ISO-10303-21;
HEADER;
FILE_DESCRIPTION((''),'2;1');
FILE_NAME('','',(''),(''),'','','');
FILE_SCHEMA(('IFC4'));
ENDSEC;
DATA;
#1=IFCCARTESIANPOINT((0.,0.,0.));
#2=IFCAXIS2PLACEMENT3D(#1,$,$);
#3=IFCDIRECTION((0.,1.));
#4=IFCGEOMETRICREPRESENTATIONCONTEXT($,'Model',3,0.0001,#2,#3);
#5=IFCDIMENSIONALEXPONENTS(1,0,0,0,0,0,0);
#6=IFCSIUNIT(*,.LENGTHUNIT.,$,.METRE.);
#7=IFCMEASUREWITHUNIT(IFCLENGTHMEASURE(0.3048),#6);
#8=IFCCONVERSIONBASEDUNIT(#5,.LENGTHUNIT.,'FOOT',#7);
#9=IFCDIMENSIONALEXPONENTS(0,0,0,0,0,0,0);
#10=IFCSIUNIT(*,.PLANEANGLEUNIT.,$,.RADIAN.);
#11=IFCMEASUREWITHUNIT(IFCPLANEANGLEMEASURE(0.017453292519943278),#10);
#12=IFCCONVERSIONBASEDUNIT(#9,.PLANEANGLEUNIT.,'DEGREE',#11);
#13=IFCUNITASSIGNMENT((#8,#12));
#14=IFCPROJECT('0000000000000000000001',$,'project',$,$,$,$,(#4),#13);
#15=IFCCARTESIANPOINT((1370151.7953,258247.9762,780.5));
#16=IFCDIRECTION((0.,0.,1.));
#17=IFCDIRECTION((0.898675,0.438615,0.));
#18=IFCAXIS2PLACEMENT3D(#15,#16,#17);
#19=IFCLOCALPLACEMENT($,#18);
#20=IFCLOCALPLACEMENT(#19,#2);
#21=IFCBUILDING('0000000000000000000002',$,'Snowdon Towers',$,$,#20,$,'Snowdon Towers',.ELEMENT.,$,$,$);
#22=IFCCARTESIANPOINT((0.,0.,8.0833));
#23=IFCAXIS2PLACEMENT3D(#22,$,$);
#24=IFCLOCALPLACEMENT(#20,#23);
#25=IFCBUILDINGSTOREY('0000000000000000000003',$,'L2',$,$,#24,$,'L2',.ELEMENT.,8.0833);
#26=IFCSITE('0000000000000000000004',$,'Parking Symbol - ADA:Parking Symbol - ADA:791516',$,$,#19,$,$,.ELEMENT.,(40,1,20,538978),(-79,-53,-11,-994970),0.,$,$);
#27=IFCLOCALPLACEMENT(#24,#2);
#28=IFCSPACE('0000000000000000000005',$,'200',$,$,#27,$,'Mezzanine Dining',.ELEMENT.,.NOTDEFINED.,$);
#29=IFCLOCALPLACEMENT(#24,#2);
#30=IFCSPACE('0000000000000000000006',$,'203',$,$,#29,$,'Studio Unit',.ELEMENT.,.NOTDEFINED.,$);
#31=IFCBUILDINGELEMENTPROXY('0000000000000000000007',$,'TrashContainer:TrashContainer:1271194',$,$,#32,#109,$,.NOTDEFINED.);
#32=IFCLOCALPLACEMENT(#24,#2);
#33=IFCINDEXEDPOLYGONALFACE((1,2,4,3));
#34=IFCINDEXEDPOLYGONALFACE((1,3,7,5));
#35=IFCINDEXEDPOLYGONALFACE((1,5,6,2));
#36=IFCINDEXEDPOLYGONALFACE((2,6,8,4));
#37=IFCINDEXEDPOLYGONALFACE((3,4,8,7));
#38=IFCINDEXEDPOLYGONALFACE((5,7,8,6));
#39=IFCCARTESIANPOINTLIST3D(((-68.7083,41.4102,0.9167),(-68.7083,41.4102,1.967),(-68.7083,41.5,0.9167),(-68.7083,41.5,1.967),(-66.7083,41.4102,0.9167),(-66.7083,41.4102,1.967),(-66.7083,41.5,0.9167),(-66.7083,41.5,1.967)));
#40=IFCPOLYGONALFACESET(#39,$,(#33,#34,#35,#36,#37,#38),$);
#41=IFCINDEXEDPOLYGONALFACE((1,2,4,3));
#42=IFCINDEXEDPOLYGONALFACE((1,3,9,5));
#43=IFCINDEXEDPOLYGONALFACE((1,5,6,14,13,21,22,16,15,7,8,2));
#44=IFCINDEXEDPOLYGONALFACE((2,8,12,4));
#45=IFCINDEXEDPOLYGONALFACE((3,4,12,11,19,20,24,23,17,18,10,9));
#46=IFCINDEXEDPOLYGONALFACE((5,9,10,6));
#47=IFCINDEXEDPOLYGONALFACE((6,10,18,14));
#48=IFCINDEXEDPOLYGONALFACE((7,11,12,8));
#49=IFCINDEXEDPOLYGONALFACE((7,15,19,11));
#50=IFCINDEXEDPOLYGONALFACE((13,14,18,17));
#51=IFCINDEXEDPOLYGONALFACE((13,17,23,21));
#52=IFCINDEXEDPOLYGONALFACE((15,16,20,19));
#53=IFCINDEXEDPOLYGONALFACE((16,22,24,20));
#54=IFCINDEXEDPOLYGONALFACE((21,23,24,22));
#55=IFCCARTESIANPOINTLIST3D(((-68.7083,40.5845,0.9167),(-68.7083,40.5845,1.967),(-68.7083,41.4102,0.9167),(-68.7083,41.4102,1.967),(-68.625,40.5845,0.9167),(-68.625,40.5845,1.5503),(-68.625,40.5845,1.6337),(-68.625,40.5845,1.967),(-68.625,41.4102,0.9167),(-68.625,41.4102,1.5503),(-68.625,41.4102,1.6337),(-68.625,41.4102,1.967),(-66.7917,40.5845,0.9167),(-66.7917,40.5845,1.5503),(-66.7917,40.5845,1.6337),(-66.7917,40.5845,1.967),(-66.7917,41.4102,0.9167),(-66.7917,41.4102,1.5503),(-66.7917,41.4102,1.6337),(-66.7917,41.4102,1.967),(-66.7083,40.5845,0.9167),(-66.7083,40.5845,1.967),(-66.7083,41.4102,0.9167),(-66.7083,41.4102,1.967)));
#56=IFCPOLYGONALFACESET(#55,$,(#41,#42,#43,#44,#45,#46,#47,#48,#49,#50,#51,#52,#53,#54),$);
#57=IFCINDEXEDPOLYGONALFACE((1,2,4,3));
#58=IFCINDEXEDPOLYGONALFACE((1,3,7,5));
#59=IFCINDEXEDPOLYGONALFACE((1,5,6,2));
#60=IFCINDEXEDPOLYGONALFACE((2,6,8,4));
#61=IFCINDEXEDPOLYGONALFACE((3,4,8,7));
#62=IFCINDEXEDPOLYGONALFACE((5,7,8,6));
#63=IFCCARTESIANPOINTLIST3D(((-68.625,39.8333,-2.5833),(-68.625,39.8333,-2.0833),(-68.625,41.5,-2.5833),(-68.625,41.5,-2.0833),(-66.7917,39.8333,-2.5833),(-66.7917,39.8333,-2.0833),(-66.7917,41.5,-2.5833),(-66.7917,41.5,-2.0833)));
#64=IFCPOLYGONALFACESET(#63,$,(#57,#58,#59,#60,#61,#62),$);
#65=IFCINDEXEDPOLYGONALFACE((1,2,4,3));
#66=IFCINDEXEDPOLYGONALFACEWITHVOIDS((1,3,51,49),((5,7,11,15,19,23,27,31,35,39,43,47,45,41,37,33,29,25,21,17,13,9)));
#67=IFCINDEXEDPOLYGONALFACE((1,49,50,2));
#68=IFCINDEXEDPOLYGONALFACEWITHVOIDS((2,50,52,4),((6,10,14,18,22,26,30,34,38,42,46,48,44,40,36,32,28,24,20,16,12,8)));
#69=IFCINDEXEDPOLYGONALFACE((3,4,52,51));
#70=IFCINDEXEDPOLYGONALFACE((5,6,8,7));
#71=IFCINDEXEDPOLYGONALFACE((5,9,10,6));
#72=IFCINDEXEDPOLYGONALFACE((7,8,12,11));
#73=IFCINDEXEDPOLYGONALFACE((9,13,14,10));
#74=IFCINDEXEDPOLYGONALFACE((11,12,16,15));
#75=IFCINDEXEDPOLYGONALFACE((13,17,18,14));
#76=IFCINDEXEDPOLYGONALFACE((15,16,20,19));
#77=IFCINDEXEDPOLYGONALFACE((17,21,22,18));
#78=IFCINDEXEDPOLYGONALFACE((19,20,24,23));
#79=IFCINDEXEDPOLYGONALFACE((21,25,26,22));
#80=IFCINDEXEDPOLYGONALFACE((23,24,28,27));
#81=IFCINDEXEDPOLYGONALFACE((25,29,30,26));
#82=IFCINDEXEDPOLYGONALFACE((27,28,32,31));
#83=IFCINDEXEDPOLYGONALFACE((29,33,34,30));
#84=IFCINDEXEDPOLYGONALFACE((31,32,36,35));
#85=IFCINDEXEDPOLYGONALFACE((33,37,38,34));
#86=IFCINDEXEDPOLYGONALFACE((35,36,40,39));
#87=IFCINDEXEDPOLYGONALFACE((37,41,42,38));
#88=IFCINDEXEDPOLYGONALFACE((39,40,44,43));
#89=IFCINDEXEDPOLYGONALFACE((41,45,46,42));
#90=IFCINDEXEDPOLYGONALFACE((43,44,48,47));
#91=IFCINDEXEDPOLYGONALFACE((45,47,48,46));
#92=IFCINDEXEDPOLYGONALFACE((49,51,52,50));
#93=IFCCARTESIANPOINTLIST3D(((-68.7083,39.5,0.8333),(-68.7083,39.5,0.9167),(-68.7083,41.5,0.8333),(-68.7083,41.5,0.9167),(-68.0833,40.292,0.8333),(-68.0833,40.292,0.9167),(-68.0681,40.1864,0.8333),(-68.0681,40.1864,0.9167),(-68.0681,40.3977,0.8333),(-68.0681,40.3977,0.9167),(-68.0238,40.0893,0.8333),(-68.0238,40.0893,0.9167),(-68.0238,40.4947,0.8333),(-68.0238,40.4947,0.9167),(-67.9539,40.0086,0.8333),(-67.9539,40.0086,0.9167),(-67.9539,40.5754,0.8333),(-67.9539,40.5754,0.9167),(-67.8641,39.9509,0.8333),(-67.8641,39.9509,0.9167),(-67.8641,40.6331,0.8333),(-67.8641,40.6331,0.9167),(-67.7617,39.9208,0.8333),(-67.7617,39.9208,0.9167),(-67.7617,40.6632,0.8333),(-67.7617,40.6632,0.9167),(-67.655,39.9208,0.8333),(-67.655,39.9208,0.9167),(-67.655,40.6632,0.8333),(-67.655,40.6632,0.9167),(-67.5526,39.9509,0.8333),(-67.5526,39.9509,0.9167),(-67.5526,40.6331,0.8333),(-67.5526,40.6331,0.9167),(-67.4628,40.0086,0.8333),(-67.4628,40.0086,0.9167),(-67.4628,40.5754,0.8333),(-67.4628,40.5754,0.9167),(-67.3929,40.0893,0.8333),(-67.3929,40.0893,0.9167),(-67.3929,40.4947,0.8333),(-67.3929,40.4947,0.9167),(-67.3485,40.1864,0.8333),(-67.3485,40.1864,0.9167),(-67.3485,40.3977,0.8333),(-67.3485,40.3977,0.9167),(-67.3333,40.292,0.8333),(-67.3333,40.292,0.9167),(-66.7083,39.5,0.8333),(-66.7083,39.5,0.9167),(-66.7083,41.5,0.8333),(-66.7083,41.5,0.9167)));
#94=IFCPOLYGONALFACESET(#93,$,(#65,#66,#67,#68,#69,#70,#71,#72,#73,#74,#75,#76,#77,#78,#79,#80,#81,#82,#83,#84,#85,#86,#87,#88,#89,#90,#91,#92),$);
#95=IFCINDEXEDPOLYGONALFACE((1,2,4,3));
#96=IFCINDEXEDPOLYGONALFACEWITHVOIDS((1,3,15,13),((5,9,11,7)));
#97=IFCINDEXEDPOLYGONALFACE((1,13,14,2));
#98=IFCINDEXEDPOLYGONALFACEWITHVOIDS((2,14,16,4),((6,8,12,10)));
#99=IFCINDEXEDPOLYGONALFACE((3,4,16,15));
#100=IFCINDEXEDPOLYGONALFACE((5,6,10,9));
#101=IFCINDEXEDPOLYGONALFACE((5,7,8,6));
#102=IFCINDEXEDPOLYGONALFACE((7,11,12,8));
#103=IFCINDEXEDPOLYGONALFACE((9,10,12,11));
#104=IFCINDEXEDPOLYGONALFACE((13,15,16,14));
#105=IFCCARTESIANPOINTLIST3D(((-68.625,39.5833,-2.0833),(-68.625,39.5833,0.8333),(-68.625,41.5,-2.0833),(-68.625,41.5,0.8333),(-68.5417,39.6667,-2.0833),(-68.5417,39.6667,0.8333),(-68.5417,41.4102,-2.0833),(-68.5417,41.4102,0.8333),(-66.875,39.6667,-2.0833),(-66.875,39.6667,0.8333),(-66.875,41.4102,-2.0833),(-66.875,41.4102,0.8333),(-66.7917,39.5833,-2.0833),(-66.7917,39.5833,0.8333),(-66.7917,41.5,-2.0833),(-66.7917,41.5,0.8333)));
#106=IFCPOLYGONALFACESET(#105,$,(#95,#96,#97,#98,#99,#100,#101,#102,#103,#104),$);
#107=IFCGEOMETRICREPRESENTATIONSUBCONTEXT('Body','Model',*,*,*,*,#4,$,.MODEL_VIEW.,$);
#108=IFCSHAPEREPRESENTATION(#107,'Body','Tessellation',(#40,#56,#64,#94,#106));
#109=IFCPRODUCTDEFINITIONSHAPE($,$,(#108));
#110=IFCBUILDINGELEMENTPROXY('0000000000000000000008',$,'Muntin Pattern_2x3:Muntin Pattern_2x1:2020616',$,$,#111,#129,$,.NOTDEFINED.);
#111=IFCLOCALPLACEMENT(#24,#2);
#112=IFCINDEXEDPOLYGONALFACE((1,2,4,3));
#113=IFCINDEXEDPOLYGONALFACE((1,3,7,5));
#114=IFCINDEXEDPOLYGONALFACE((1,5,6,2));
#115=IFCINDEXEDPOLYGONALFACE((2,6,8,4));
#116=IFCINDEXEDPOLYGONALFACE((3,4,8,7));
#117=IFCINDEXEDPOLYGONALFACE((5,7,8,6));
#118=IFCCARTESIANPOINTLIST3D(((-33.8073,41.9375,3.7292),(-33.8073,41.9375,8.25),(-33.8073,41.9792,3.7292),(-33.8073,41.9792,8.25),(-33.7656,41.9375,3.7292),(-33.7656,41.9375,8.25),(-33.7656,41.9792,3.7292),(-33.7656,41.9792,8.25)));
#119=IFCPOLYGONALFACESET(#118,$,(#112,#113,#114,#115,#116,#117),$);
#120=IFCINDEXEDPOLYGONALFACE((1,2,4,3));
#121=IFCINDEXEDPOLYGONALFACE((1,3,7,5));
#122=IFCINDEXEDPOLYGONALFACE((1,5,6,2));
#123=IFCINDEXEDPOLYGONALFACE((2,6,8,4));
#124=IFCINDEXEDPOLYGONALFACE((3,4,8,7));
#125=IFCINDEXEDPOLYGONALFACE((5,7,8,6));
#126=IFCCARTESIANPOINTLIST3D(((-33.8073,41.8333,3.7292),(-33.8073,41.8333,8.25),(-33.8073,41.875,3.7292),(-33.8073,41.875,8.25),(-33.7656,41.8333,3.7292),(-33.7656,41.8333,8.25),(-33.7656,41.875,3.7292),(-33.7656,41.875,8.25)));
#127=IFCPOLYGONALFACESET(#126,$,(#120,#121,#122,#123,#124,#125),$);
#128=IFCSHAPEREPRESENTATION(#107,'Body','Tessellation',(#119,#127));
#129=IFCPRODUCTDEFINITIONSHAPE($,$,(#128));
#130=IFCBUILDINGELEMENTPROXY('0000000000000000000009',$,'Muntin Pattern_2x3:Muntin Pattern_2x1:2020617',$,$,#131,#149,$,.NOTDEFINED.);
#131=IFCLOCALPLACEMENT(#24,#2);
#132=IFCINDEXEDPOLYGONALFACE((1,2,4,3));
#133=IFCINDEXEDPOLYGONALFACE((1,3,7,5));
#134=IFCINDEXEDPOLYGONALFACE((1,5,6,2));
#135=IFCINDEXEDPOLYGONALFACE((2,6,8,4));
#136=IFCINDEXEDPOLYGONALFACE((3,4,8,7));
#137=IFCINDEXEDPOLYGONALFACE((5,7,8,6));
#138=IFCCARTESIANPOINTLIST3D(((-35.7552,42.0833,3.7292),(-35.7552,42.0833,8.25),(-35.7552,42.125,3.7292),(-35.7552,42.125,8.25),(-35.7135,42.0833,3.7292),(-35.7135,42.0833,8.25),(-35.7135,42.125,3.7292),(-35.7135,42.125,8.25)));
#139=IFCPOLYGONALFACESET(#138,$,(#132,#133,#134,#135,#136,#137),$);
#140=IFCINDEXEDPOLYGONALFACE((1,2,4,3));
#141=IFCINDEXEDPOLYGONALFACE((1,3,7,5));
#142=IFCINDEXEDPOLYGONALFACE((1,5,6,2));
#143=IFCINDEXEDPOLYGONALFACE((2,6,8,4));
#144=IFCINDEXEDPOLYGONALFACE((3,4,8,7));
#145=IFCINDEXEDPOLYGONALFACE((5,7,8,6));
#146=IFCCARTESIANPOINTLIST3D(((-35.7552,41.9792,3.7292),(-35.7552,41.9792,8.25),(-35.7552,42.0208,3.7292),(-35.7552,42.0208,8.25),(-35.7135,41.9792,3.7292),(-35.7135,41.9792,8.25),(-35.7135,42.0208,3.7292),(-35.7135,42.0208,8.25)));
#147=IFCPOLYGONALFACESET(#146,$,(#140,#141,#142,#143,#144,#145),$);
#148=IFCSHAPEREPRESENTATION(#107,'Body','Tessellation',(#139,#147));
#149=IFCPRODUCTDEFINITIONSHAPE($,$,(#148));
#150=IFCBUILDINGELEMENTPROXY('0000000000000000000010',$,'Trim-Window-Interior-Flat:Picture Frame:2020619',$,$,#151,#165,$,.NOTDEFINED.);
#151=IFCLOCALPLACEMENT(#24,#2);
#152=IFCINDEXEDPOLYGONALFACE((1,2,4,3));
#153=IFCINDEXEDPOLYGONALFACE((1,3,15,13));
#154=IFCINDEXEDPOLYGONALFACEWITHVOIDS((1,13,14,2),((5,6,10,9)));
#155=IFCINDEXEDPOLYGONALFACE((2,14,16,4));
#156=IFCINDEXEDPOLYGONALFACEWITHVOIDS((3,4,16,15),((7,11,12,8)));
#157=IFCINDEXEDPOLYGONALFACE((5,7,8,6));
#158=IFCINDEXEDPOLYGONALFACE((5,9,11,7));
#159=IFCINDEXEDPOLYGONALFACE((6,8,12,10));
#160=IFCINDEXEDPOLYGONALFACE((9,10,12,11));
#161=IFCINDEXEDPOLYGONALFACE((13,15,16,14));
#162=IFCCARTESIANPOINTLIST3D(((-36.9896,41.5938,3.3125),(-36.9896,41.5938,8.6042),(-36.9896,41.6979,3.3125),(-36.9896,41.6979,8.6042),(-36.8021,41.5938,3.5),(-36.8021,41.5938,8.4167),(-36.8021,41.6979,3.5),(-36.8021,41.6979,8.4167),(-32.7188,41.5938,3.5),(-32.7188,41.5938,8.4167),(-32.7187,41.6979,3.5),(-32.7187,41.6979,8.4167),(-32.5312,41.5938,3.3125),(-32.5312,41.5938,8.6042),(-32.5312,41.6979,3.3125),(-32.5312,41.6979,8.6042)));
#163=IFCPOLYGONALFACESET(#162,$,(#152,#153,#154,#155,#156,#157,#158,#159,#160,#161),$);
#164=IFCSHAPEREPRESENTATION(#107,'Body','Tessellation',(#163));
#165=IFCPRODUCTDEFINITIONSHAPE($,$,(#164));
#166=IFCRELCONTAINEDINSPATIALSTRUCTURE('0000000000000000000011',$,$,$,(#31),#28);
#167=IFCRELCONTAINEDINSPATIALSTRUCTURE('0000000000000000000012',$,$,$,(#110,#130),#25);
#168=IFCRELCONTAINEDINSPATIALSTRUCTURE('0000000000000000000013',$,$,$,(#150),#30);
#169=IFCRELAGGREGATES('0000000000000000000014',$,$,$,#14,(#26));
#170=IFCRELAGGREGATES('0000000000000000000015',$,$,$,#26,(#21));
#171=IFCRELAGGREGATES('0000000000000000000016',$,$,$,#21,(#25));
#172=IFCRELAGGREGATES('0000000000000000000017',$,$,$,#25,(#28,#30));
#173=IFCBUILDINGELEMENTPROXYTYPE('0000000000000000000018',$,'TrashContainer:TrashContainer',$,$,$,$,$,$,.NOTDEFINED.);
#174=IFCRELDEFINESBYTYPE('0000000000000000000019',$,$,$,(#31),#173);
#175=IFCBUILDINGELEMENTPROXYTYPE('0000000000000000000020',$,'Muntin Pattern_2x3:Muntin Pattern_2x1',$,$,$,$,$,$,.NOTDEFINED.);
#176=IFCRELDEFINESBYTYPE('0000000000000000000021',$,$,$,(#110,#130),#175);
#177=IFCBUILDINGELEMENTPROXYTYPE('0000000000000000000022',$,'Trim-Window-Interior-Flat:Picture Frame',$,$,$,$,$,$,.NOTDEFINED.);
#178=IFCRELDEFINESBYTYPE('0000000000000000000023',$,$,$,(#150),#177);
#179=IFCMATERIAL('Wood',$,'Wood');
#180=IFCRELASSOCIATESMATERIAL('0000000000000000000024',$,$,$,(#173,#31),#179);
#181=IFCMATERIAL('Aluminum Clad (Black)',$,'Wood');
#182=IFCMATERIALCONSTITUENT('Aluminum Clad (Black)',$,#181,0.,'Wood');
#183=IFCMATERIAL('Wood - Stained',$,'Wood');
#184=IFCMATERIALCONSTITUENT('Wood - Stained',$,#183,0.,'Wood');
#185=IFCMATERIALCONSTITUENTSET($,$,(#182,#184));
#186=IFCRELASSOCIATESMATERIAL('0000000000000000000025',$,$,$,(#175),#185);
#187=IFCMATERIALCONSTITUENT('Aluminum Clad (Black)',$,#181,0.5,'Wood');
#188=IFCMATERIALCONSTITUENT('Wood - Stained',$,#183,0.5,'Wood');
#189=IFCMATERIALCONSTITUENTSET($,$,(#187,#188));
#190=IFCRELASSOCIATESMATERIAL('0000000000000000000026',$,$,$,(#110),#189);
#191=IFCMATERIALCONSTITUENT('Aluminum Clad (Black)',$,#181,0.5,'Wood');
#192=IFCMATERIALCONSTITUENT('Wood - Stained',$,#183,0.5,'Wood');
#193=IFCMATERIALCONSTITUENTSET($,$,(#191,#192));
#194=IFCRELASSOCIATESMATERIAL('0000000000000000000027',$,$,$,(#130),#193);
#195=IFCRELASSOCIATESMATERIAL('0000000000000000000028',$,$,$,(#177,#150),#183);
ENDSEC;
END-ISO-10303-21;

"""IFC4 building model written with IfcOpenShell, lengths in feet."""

from ifc_helpers import new_model, entity, si_unit, converted_unit, direction, frame, origin, place, context, subcontext, project, spatial, arc, indexed_curve, outline, extrude, source, transform, mapped, material, constituent, constituent_set, type_object, type_shapes, element, save


model = new_model("IFC4")

# Units and contexts
model_context = context("Model", 3, precision=0.0001, world=origin(), true_north=direction((0.0, 1.0)))
body_context = subcontext(model_context, "Body", "Model", "MODEL_VIEW")
ifc_project = project(units=[converted_unit("LENGTHUNIT", "FOOT", entity("IfcLengthMeasure", 0.3048), si_unit("LENGTHUNIT", "METRE"), dimensions=[1, 0, 0, 0, 0, 0, 0]), converted_unit("PLANEANGLEUNIT", "DEGREE", entity("IfcPlaneAngleMeasure", 0.017453292519943278), si_unit("PLANEANGLEUNIT", "RADIAN"), dimensions=[0, 0, 0, 0, 0, 0, 0])], contexts=[model_context])

# Site, building, storey
site_placement = place(None, frame((1370151.7953, 258247.9762, 780.5), z_axis=(0.0, 0.0, 1.0), x_axis=(0.898675, 0.438615, 0.0)))
site = spatial("IfcSite", under=ifc_project, at=site_placement, Name="Parking Symbol - ADA:Parking Symbol - ADA:791516", CompositionType="ELEMENT", RefLatitude=(40, 1, 20, 538978), RefLongitude=(-79, -53, -11, -994970), RefElevation=0.0)
building_placement = place(site_placement, origin())
building = spatial("IfcBuilding", under=site, at=building_placement, Name="Snowdon Towers", LongName="Snowdon Towers", CompositionType="ELEMENT")
storey_placement = place(building_placement, frame((0.0, 0.0, 8.0833)))
storey = spatial("IfcBuildingStorey", under=building, at=storey_placement, Name="L2", LongName="L2", CompositionType="ELEMENT", Elevation=8.0833)

# Shared definitions
space_1_placement = place(storey_placement, origin())
space_1 = spatial("IfcSpace", under=storey, at=space_1_placement, Name="200", LongName="Mezzanine Dining", CompositionType="ELEMENT", PredefinedType="NOTDEFINED")

# Building element proxies
ifc_material_1 = material(Name="Wood", Category="Wood")
building_element_proxy_type_1 = type_object("IfcBuildingElementProxyType", Name="TrashContainer:TrashContainer", PredefinedType="NOTDEFINED", material=ifc_material_1)
shared_shape_1 = source(origin(), body_context, "Body", "SweptSolid", [
    extrude(outline(indexed_curve([(-1.0, -0.0449), (1.0, -0.0449), (1.0, 0.0449), (-1.0, 0.0449), (-1.0, -0.0449)], self_intersect=False)), frame((1.0, 1.9551, 3.5), z_axis=(0.0, 0.0, 1.0), x_axis=(-1.0, 0.0, 0.0)), (0.0, 0.0, 1.0), 1.0503),
    extrude(outline(indexed_curve([(-1.0, -0.4751), (-0.9167, -0.4751), (-0.9167, -0.1418), (0.9167, -0.1418), (0.9167, -0.4751), (1.0, -0.4751), (1.0, 0.5752), (0.9167, 0.5752), (0.9167, -0.0584), (-0.9167, -0.0584), (-0.9167, 0.5752), (-1.0, 0.5752), (-1.0, -0.4751)], self_intersect=False)), frame((1.0, 1.0845, 4.0752), z_axis=(0.0, 1.0, 0.0), x_axis=(1.0, 0.0, 0.0)), (0.0, 0.0, 1.0), 0.8256),
    extrude(outline(indexed_curve([(-0.9167, -0.8333), (0.9167, -0.8333), (0.9167, 0.8333), (-0.9167, 0.8333), (-0.9167, -0.8333)], self_intersect=False)), frame((1.0, 1.1667, 0.0), z_axis=(0.0, 0.0, 1.0), x_axis=(-1.0, 0.0, 0.0)), (0.0, 0.0, 1.0), 0.5),
    extrude(outline(indexed_curve([(-1.0, -1.0), (1.0, -1.0), (1.0, 1.0), (-1.0, 1.0), (-1.0, -1.0)], self_intersect=False), holes=[indexed_curve([(0.208, -0.375), (-0.167, 0.0), (0.208, 0.375), (0.583, 0.0)], segments=[arc(1, 2, 3), arc(3, 4, 1)], self_intersect=False)]), frame((1.0, 1.0, 3.4167), z_axis=(0.0, 0.0, 1.0), x_axis=(0.0, -1.0, 0.0)), (0.0, 0.0, 1.0), 0.0833),
    extrude(outline(indexed_curve([(-0.9583, -0.9167), (0.9583, -0.9167), (0.9583, 0.9167), (-0.9583, 0.9167), (-0.9583, -0.9167)], self_intersect=False), holes=[indexed_curve([(-0.8685, -0.8333), (-0.8685, 0.8333), (0.875, 0.8333), (0.875, -0.8333), (-0.8685, -0.8333)], self_intersect=False)]), frame((1.0, 1.0417, 0.5), z_axis=(0.0, 0.0, 1.0), x_axis=(0.0, -1.0, 0.0)), (0.0, 0.0, 1.0), 2.9167),
])
type_shapes(building_element_proxy_type_1, [shared_shape_1])
proxy_1_placement = place(space_1_placement, frame((-68.7083, 39.5, -2.5833)))
element("IfcBuildingElementProxy", 1, at=proxy_1_placement, inside=space_1, type_object=building_element_proxy_type_1, material=ifc_material_1, Name="TrashContainer:TrashContainer:1271194", PredefinedType="NOTDEFINED", context=body_context, shape_type="MappedRepresentation", body=[
    mapped(shared_shape_1, transform((0.0, 0.0, 0.0), scale=1.0)),
])
ifc_material_2 = material(Name="Aluminum Clad (Black)", Category="Wood")
ifc_constituent_1 = constituent(ifc_material_2, Name="Aluminum Clad (Black)", Category="Wood", fraction=0.5)
ifc_material_3 = material(Name="Wood - Stained", Category="Wood")
ifc_constituent_2 = constituent(ifc_material_3, Name="Wood - Stained", Category="Wood", fraction=0.5)
ifc_constituent_set_1 = constituent_set(constituents=[ifc_constituent_1, ifc_constituent_2])
ifc_constituent_3 = constituent(ifc_material_2, Name="Aluminum Clad (Black)", Category="Wood", fraction=0.0)
ifc_constituent_4 = constituent(ifc_material_3, Name="Wood - Stained", Category="Wood", fraction=0.0)
ifc_constituent_set_2 = constituent_set(constituents=[ifc_constituent_3, ifc_constituent_4])
building_element_proxy_type_2 = type_object("IfcBuildingElementProxyType", Name="Muntin Pattern_2x3:Muntin Pattern_2x1", PredefinedType="NOTDEFINED", material=ifc_constituent_set_2)
shared_shape_2 = source(origin(), body_context, "Body", "SweptSolid", [
    extrude(outline(indexed_curve([(-0.0208, -0.0208), (0.0208, -0.0208), (0.0208, 0.0208), (-0.0208, 0.0208), (-0.0208, -0.0208)], self_intersect=False)), frame((0.0, 0.0521, 0.0), z_axis=(0.0, 0.0, 1.0), x_axis=(0.0, -1.0, 0.0)), (0.0, 0.0, 1.0), 4.5208),
    extrude(outline(indexed_curve([(-0.0208, -0.0208), (0.0208, -0.0208), (0.0208, 0.0208), (-0.0208, 0.0208), (-0.0208, -0.0208)], self_intersect=False)), frame((0.0, -0.0521, 0.0), z_axis=(0.0, 0.0, 1.0), x_axis=(0.0, -1.0, 0.0)), (0.0, 0.0, 1.0), 4.5208),
])
type_shapes(building_element_proxy_type_2, [shared_shape_2])
proxy_2_placement = place(storey_placement, frame((-33.7865, 41.9063, 3.7292)))
element("IfcBuildingElementProxy", 2, at=proxy_2_placement, inside=storey, type_object=building_element_proxy_type_2, material=ifc_constituent_set_1, Name="Muntin Pattern_2x3:Muntin Pattern_2x1:2020616", PredefinedType="NOTDEFINED", context=body_context, shape_type="MappedRepresentation", body=[
    mapped(shared_shape_2, transform((0.0, 0.0, 0.0), scale=1.0)),
])
ifc_constituent_5 = constituent(ifc_material_2, Name="Aluminum Clad (Black)", Category="Wood", fraction=0.5)
ifc_constituent_6 = constituent(ifc_material_3, Name="Wood - Stained", Category="Wood", fraction=0.5)
ifc_constituent_set_3 = constituent_set(constituents=[ifc_constituent_5, ifc_constituent_6])
proxy_3_placement = place(storey_placement, frame((-35.7344, 42.0521, 3.7292)))
element("IfcBuildingElementProxy", 3, at=proxy_3_placement, inside=storey, type_object=building_element_proxy_type_2, material=ifc_constituent_set_3, Name="Muntin Pattern_2x3:Muntin Pattern_2x1:2020617", PredefinedType="NOTDEFINED", context=body_context, shape_type="MappedRepresentation", body=[
    mapped(shared_shape_2, transform((0.0, 0.0, 0.0), scale=1.0)),
])

# Shared definitions
space_2_placement = place(storey_placement, origin())
space_2 = spatial("IfcSpace", under=storey, at=space_2_placement, Name="203", LongName="Studio Unit", CompositionType="ELEMENT", PredefinedType="NOTDEFINED")

# Building element proxy
building_element_proxy_type_3 = type_object("IfcBuildingElementProxyType", Name="Trim-Window-Interior-Flat:Picture Frame", PredefinedType="NOTDEFINED", material=ifc_material_3)
shared_shape_3 = source(origin(), body_context, "Body", "SweptSolid", [
    extrude(outline(indexed_curve([(-2.2292, -2.6458), (2.2292, -2.6458), (2.2292, 2.6458), (-2.2292, 2.6458), (-2.2292, -2.6458)], self_intersect=False), holes=[indexed_curve([(-2.0417, -2.4583), (-2.0417, 2.4583), (2.0417, 2.4583), (2.0417, -2.4583), (-2.0417, -2.4583)], self_intersect=False)]), frame((0.0, -2.5, 0.0), z_axis=(0.0, 0.0, 1.0), x_axis=(-1.0, 0.0, 0.0)), (0.0, 0.0, 1.0), 0.1042),
])
type_shapes(building_element_proxy_type_3, [shared_shape_3])
proxy_4_placement = place(space_2_placement, frame((-34.7604, 41.6979, 8.4583), z_axis=(0.0, -1.0, 0.0), x_axis=(1.0, 0.0, 0.0)))
element("IfcBuildingElementProxy", 4, at=proxy_4_placement, inside=space_2, type_object=building_element_proxy_type_3, material=ifc_material_3, Name="Trim-Window-Interior-Flat:Picture Frame:2020619", PredefinedType="NOTDEFINED", context=body_context, shape_type="MappedRepresentation", body=[
    mapped(shared_shape_3, transform((0.0, 0.0, 0.0), scale=1.0)),
])

save(model, "model.ifc")
